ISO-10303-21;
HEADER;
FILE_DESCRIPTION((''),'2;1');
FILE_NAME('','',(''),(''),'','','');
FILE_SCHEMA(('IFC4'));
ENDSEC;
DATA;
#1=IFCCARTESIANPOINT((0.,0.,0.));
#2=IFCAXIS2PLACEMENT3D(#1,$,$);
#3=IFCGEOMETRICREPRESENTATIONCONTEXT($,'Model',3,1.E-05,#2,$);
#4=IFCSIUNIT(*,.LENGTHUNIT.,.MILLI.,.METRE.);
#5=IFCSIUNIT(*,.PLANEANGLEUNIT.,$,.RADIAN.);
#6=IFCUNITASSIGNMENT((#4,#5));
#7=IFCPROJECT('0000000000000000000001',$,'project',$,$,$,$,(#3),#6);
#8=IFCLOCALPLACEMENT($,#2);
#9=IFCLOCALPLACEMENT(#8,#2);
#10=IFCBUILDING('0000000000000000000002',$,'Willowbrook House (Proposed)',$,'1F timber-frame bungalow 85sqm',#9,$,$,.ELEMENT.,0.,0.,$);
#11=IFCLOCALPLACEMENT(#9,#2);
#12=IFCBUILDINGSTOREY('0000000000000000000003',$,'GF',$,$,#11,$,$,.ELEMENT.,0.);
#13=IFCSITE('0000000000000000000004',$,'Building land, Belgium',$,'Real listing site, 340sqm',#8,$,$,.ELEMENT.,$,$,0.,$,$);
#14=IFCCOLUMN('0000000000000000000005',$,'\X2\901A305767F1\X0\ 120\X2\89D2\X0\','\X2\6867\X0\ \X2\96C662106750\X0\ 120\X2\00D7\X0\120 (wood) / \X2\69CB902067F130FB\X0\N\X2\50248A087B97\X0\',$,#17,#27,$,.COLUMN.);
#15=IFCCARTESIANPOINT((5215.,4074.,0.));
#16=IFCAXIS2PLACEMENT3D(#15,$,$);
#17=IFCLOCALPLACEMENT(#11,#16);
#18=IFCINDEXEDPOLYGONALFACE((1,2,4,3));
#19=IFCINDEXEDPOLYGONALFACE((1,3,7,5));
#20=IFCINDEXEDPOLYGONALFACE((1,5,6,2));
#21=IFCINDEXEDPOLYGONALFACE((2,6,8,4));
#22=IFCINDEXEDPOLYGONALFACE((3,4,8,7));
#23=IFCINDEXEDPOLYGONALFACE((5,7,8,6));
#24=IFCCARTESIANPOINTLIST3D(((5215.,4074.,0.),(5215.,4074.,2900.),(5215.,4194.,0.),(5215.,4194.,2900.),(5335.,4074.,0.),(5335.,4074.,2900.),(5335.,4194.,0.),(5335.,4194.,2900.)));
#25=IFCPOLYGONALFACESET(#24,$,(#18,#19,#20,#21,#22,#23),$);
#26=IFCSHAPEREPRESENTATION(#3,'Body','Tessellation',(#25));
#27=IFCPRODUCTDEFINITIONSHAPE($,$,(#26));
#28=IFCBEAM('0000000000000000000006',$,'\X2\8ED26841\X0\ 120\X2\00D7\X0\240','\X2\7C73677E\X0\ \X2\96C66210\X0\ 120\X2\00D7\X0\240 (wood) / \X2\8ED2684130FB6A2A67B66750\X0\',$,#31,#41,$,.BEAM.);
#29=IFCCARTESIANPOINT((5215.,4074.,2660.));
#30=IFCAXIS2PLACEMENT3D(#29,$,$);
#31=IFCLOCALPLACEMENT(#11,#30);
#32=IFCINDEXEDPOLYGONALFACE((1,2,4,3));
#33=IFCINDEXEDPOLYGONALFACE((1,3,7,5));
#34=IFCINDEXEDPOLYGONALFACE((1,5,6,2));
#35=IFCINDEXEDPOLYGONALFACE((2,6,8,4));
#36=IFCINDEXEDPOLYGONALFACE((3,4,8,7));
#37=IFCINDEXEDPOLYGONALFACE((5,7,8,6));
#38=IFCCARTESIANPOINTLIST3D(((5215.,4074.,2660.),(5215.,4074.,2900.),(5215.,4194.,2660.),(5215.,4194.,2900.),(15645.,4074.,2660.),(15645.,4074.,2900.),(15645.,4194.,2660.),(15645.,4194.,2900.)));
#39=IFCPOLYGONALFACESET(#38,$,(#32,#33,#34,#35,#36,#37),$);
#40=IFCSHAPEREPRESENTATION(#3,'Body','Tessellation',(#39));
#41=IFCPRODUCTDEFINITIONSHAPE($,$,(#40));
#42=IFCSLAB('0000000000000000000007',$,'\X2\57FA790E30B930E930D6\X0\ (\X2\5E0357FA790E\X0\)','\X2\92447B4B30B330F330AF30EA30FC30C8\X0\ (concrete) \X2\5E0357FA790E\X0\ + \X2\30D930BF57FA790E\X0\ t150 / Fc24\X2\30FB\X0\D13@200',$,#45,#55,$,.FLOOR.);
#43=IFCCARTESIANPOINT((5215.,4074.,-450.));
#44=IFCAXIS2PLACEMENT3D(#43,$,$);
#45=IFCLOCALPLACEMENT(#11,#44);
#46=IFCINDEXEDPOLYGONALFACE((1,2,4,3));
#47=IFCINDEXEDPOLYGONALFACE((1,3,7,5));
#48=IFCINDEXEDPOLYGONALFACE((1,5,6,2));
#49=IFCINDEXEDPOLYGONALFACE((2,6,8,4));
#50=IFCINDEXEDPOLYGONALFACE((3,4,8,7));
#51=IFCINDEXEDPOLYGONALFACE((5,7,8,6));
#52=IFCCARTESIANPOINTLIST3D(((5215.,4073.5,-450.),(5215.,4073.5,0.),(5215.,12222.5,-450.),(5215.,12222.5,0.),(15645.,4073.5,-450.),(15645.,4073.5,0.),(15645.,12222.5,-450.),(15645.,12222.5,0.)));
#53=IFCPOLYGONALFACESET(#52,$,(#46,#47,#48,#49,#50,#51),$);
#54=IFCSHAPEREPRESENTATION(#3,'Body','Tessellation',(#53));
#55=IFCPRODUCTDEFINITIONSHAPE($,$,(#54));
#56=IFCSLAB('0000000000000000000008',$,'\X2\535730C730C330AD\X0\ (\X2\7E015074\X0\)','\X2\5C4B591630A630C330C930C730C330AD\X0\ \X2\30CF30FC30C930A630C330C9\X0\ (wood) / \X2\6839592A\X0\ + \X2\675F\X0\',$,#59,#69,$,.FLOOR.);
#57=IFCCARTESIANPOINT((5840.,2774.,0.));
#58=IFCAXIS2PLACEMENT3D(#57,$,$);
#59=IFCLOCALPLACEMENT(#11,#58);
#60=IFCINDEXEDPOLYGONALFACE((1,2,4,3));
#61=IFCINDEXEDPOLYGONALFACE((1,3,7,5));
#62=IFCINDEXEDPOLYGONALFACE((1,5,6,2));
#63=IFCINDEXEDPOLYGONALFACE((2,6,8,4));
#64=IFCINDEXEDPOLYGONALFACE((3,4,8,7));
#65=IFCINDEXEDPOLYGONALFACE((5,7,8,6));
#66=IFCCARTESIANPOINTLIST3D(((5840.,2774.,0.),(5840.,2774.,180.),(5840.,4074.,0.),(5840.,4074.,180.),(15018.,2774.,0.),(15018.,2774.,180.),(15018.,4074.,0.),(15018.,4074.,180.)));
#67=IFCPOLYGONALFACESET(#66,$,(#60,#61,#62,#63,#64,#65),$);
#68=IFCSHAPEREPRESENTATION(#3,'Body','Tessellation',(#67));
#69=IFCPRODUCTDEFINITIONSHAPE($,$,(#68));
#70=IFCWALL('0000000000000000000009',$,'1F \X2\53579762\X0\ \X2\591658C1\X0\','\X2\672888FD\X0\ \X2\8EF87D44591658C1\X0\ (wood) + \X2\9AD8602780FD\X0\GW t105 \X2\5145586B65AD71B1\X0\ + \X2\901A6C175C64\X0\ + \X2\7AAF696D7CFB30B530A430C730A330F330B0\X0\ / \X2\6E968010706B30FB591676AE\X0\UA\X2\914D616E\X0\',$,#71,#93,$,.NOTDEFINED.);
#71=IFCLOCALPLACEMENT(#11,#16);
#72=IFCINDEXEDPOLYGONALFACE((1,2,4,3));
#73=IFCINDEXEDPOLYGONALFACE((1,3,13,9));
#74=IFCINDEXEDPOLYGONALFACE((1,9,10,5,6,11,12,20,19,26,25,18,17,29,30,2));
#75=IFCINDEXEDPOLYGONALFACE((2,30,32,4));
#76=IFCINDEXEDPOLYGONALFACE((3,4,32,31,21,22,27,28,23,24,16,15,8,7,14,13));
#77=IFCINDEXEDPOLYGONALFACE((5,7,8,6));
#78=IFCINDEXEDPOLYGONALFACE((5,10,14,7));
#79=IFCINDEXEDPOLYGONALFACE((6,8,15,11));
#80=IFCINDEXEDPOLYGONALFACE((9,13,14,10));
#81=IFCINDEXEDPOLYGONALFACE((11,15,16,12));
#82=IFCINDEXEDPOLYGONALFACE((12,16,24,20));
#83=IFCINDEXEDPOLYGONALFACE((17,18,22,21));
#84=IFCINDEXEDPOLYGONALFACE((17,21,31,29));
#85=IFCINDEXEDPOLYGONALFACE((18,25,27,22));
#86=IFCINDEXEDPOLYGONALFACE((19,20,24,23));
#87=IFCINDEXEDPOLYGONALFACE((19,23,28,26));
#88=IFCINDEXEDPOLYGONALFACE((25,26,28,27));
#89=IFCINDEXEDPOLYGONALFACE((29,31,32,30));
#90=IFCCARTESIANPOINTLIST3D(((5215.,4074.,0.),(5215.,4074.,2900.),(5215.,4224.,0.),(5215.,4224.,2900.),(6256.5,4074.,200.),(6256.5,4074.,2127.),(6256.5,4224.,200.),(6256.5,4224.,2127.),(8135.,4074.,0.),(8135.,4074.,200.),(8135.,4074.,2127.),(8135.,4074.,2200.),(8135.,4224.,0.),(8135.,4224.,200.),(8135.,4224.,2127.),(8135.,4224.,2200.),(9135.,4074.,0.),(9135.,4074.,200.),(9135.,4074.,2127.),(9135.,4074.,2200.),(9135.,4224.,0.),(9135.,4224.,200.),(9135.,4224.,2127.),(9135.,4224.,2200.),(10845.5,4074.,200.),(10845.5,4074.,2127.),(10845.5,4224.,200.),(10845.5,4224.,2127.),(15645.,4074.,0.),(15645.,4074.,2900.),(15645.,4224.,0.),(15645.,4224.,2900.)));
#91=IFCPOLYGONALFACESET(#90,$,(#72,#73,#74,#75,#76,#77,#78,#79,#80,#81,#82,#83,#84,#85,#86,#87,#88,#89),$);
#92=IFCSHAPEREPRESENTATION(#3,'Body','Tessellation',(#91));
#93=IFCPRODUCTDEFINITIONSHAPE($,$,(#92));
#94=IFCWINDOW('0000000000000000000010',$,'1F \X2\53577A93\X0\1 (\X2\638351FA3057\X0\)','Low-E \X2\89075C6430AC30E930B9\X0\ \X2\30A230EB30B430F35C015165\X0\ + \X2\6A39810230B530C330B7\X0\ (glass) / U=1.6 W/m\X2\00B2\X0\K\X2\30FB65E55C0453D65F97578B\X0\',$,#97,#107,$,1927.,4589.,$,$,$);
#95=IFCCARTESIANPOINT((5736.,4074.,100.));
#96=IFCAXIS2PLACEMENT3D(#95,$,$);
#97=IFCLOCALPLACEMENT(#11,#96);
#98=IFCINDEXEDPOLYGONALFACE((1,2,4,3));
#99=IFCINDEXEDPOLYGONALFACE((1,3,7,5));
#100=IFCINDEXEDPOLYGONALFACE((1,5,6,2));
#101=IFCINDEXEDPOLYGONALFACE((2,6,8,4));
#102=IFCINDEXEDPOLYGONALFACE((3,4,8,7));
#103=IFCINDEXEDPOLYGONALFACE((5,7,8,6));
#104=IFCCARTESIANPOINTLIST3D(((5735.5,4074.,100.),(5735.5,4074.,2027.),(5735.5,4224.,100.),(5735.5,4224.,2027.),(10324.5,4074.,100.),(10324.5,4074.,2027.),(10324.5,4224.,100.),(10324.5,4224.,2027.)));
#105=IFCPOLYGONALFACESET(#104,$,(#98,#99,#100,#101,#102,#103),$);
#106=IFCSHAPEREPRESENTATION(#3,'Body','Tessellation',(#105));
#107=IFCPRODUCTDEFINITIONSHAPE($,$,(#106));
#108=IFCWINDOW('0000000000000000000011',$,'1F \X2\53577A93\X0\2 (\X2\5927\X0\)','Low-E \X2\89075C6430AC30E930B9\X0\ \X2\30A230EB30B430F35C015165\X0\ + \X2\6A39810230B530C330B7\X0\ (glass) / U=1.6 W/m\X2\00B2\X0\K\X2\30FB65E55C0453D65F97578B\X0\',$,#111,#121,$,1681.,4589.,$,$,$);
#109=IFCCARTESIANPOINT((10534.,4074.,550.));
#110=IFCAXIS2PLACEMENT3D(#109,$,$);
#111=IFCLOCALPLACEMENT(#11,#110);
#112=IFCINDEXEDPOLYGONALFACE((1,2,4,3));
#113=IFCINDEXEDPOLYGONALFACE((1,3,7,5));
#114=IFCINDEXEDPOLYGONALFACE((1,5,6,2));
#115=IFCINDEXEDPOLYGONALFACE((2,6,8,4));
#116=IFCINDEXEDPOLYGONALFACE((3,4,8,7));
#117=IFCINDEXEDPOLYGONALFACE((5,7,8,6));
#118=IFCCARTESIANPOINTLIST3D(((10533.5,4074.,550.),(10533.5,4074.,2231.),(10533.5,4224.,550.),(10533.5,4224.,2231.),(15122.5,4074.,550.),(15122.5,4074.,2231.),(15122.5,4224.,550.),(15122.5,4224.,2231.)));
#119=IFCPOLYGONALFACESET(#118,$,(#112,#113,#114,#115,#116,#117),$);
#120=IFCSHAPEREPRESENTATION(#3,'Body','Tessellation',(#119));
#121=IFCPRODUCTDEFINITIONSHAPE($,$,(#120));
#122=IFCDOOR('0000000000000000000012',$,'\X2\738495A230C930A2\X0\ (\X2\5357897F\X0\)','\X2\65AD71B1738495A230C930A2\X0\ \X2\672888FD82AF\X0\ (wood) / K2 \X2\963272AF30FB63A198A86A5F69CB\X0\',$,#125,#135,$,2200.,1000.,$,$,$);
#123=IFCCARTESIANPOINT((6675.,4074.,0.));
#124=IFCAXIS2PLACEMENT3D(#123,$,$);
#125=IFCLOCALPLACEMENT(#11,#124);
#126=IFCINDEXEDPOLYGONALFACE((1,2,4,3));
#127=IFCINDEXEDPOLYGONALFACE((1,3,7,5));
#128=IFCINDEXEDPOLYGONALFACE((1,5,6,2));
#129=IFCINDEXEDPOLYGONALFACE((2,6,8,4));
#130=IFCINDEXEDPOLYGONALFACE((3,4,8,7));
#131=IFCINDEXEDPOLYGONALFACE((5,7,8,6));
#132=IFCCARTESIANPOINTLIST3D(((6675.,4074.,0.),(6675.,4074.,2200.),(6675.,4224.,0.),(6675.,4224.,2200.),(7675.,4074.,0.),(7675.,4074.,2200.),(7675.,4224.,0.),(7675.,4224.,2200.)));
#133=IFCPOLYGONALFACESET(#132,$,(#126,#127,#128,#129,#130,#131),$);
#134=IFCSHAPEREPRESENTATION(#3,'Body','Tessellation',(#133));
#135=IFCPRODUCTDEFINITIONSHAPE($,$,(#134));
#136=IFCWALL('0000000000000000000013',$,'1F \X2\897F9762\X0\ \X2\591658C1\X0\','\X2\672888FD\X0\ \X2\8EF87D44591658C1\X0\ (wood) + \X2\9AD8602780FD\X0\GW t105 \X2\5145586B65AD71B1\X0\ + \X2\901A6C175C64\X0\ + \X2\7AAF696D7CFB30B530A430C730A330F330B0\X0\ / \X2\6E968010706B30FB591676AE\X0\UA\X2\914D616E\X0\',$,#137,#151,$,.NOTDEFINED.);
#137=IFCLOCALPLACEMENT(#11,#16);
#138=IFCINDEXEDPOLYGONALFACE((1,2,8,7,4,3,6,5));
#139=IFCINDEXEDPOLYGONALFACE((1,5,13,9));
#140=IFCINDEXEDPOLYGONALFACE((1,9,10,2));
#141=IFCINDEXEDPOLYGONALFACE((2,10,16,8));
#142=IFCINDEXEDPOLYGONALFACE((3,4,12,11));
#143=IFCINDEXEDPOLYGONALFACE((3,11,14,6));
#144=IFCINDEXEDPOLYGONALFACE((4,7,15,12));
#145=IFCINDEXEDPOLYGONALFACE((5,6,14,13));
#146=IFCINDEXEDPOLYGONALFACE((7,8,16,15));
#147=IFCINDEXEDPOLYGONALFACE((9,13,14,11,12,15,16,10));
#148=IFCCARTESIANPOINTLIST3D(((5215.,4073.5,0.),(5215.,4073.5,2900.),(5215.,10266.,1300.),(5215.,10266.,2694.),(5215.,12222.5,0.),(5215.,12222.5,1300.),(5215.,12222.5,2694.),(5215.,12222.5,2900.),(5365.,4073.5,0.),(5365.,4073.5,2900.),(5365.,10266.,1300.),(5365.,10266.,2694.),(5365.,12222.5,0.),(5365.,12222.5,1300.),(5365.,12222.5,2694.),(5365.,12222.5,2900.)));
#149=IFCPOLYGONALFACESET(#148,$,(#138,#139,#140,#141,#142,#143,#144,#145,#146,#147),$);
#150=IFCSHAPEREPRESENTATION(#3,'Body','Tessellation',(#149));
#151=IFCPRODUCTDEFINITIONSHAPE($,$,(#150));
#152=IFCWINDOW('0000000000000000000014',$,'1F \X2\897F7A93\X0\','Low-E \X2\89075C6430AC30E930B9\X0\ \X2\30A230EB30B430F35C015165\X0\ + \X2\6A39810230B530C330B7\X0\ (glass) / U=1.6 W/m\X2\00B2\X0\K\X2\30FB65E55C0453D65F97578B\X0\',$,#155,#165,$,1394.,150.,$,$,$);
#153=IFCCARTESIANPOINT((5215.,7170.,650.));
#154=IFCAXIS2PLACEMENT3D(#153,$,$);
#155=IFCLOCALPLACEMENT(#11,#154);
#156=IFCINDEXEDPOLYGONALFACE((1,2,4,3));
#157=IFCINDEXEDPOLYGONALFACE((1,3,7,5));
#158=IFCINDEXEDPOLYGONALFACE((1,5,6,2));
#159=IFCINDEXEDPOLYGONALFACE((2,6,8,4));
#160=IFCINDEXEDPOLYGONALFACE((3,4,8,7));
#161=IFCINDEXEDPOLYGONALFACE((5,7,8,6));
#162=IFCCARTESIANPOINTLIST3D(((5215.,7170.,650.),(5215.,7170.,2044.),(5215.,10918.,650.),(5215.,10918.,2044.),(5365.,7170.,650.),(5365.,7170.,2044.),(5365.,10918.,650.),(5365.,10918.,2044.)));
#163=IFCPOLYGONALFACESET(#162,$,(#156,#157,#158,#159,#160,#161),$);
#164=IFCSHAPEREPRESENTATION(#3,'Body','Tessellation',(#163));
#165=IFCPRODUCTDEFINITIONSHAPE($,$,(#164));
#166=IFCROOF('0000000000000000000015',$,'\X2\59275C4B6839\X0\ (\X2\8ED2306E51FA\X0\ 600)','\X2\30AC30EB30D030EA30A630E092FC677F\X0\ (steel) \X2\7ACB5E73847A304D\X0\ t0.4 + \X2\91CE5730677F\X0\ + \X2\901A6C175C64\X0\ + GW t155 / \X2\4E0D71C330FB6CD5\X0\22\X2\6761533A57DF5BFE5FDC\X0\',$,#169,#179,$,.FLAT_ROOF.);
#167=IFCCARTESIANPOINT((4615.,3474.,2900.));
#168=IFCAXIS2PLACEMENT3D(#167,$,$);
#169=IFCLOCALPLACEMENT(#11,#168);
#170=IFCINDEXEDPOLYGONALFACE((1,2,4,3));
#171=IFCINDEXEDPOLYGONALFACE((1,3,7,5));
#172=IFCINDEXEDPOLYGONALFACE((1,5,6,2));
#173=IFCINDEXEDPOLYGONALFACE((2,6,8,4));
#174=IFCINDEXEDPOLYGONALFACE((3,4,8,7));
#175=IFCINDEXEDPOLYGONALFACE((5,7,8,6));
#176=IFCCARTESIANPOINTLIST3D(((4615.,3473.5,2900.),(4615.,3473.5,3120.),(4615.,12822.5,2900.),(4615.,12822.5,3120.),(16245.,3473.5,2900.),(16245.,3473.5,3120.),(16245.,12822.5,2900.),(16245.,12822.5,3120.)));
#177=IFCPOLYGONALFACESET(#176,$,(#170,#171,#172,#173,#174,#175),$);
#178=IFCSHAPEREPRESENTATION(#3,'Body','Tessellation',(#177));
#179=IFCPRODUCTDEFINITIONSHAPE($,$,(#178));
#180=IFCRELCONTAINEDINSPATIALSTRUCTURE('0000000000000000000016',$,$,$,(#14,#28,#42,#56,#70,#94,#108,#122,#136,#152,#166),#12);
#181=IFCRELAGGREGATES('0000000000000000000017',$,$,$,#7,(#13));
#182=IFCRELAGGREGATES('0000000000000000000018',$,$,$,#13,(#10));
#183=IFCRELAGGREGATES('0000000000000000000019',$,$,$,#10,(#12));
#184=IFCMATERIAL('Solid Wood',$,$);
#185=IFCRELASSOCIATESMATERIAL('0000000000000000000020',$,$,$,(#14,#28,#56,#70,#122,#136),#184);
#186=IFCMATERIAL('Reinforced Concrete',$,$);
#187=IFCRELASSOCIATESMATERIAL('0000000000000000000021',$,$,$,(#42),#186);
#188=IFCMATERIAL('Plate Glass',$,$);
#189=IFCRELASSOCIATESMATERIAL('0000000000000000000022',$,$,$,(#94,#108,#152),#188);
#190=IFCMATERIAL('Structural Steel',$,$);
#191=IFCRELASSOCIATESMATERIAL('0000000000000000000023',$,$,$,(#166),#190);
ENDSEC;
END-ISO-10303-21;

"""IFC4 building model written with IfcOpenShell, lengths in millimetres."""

from ifc_helpers import new_model, si_unit, frame, frame_2d, origin, place, context, project, spatial, rectangle, extrude, material, element, fill, save


model = new_model("IFC4")

# Units and contexts
model_context = context("Model", 3, precision=1e-05, world=origin())
ifc_project = project(units=[si_unit("LENGTHUNIT", "METRE", prefix="MILLI"), si_unit("PLANEANGLEUNIT", "RADIAN")], contexts=[model_context])

# Site, building, storey
site_placement = place(None, origin())
site = spatial("IfcSite", under=ifc_project, at=site_placement, Name="Building land, Belgium", ObjectType="Real listing site, 340sqm", CompositionType="ELEMENT", RefElevation=0.0)
building_placement = place(site_placement, origin())
building = spatial("IfcBuilding", under=site, at=building_placement, Name="Willowbrook House (Proposed)", ObjectType="1F timber-frame bungalow 85sqm", CompositionType="ELEMENT", ElevationOfRefHeight=0.0, ElevationOfTerrain=0.0)
storey_placement = place(building_placement, origin())
storey = spatial("IfcBuildingStorey", under=building, at=storey_placement, Name="GF", CompositionType="ELEMENT", Elevation=0.0)

# Column
ifc_material_1 = material(Name="Solid Wood")
column_1_placement = place(storey_placement, frame((5215.0, 4074.0, 0.0)))
element("IfcColumn", 1, at=column_1_placement, inside=storey, material=ifc_material_1, Name="通し柱 120角", Description="桧 集成材 120×120 (wood) / 構造柱・N値計算", PredefinedType="COLUMN", context=model_context, shape_type="SweptSolid", body=[
    extrude(rectangle(XDim=120.0, YDim=120.0, at=frame_2d((60.0, 60.0))), frame((5215.0, 4074.0, 0.0)), (0.0, 0.0, 1.0), 2900.0),
])

# Beam
beam_1_placement = place(storey_placement, frame((5215.0, 4074.0, 2660.0)))
element("IfcBeam", 2, at=beam_1_placement, inside=storey, material=ifc_material_1, Name="軒桁 120×240", Description="米松 集成 120×240 (wood) / 軒桁・横架材", PredefinedType="BEAM", context=model_context, shape_type="SweptSolid", body=[
    extrude(rectangle(XDim=10430.0, YDim=120.0, at=frame_2d((5215.0, 60.0))), frame((5215.0, 4074.0, 2660.0)), (0.0, 0.0, 1.0), 240.0),
])

# Slabs
ifc_material_2 = material(Name="Reinforced Concrete")
slab_1_placement = place(storey_placement, frame((5215.0, 4074.0, -450.0)))
element("IfcSlab", 3, at=slab_1_placement, inside=storey, material=ifc_material_2, Name="基礎スラブ (布基礎)", Description="鉄筋コンクリート (concrete) 布基礎 + ベタ基礎 t150 / Fc24・D13@200", PredefinedType="FLOOR", context=model_context, shape_type="SweptSolid", body=[
    extrude(rectangle(XDim=10430.0, YDim=8149.0, at=frame_2d((5215.0, 4074.0))), frame((5215.0, 4074.0, -450.0)), (0.0, 0.0, 1.0), 450.0),
])
slab_2_placement = place(storey_placement, frame((5840.0, 2774.0, 0.0)))
element("IfcSlab", 4, at=slab_2_placement, inside=storey, material=ifc_material_1, Name="南デッキ (縁側)", Description="屋外ウッドデッキ ハードウッド (wood) / 根太 + 束", PredefinedType="FLOOR", context=model_context, shape_type="SweptSolid", body=[
    extrude(rectangle(XDim=9178.0, YDim=1300.0, at=frame_2d((4589.0, 650.0))), frame((5840.0, 2774.0, 0.0)), (0.0, 0.0, 1.0), 180.0),
])

# Wall, openings, windows, door
wall_1_placement = place(storey_placement, frame((5215.0, 4074.0, 0.0)))
wall_1 = element("IfcWall", 5, at=wall_1_placement, inside=storey, material=ifc_material_1, Name="1F 南面 外壁", Description="木製 軸組外壁 (wood) + 高性能GW t105 充填断熱 + 通気層 + 窯業系サイディング / 準耐火・外皮UA配慮", PredefinedType="NOTDEFINED", context=model_context, shape_type="SweptSolid", body=[
    extrude(rectangle(XDim=10430.0, YDim=150.0, at=frame_2d((5215.0, 75.0))), frame((5215.0, 4074.0, 0.0)), (0.0, 0.0, 1.0), 2900.0),
])
opening_1_placement = place(storey_placement, frame((5736.0, 4074.0, 100.0)))
opening_1 = element("IfcOpeningElement", 6, at=opening_1_placement, cuts=wall_1, PredefinedType="NOTDEFINED", context=model_context, shape_type="SweptSolid", body=[
    extrude(rectangle(XDim=4589.0, YDim=150.0, at=frame_2d((2294.0, 75.0))), frame((5736.0, 4074.0, 100.0)), (0.0, 0.0, 1.0), 1927.0),
])
opening_2_placement = place(storey_placement, frame((10534.0, 4074.0, 550.0)))
opening_2 = element("IfcOpeningElement", 7, at=opening_2_placement, cuts=wall_1, PredefinedType="NOTDEFINED", context=model_context, shape_type="SweptSolid", body=[
    extrude(rectangle(XDim=4589.0, YDim=150.0, at=frame_2d((2294.0, 75.0))), frame((10534.0, 4074.0, 550.0)), (0.0, 0.0, 1.0), 1681.0),
])
opening_3_placement = place(storey_placement, frame((6675.0, 4074.0, 0.0)))
opening_3 = element("IfcOpeningElement", 8, at=opening_3_placement, cuts=wall_1, PredefinedType="NOTDEFINED", context=model_context, shape_type="SweptSolid", body=[
    extrude(rectangle(XDim=1000.0, YDim=150.0, at=frame_2d((500.0, 75.0))), frame((6675.0, 4074.0, 0.0)), (0.0, 0.0, 1.0), 2200.0),
])
ifc_material_3 = material(Name="Plate Glass")
window_1_placement = place(storey_placement, frame((5736.0, 4074.0, 100.0)))
window_1 = element("IfcWindow", 9, at=window_1_placement, inside=storey, material=ifc_material_3, Name="1F 南窓1 (掃出し)", Description="Low-E 複層ガラス アルゴン封入 + 樹脂サッシ (glass) / U=1.6 W/m²K・日射取得型", OverallHeight=1927.0, OverallWidth=4589.0, context=model_context, shape_type="SweptSolid", body=[
    extrude(rectangle(XDim=4589.0, YDim=150.0, at=frame_2d((2294.0, 75.0))), frame((5736.0, 4074.0, 100.0)), (0.0, 0.0, 1.0), 1927.0),
])
fill(opening_1, window_1)
window_2_placement = place(storey_placement, frame((10534.0, 4074.0, 550.0)))
window_2 = element("IfcWindow", 10, at=window_2_placement, inside=storey, material=ifc_material_3, Name="1F 南窓2 (大)", Description="Low-E 複層ガラス アルゴン封入 + 樹脂サッシ (glass) / U=1.6 W/m²K・日射取得型", OverallHeight=1681.0, OverallWidth=4589.0, context=model_context, shape_type="SweptSolid", body=[
    extrude(rectangle(XDim=4589.0, YDim=150.0, at=frame_2d((2294.0, 75.0))), frame((10534.0, 4074.0, 550.0)), (0.0, 0.0, 1.0), 1681.0),
])
fill(opening_2, window_2)
door_placement = place(storey_placement, frame((6675.0, 4074.0, 0.0)))
door = element("IfcDoor", 11, at=door_placement, inside=storey, material=ifc_material_1, Name="玄関ドア (南西)", Description="断熱玄関ドア 木製芯 (wood) / K2 防犯・採風機構", OverallHeight=2200.0, OverallWidth=1000.0, context=model_context, shape_type="SweptSolid", body=[
    extrude(rectangle(XDim=1000.0, YDim=150.0, at=frame_2d((500.0, 75.0))), frame((6675.0, 4074.0, 0.0)), (0.0, 0.0, 1.0), 2200.0),
])
fill(opening_3, door)

# Wall, opening, window
wall_2_placement = place(storey_placement, frame((5215.0, 4074.0, 0.0)))
wall_2 = element("IfcWall", 12, at=wall_2_placement, inside=storey, material=ifc_material_1, Name="1F 西面 外壁", Description="木製 軸組外壁 (wood) + 高性能GW t105 充填断熱 + 通気層 + 窯業系サイディング / 準耐火・外皮UA配慮", PredefinedType="NOTDEFINED", context=model_context, shape_type="SweptSolid", body=[
    extrude(rectangle(XDim=150.0, YDim=8149.0, at=frame_2d((75.0, 4074.0))), frame((5215.0, 4074.0, 0.0)), (0.0, 0.0, 1.0), 2900.0),
])
opening_4_placement = place(storey_placement, frame((5215.0, 7170.0, 650.0)))
opening_4 = element("IfcOpeningElement", 13, at=opening_4_placement, cuts=wall_2, PredefinedType="NOTDEFINED", context=model_context, shape_type="SweptSolid", body=[
    extrude(rectangle(XDim=150.0, YDim=3748.0, at=frame_2d((75.0, 1874.0))), frame((5215.0, 7170.0, 650.0)), (0.0, 0.0, 1.0), 1394.0),
])
window_3_placement = place(storey_placement, frame((5215.0, 7170.0, 650.0)))
window_3 = element("IfcWindow", 14, at=window_3_placement, inside=storey, material=ifc_material_3, Name="1F 西窓", Description="Low-E 複層ガラス アルゴン封入 + 樹脂サッシ (glass) / U=1.6 W/m²K・日射取得型", OverallHeight=1394.0, OverallWidth=150.0, context=model_context, shape_type="SweptSolid", body=[
    extrude(rectangle(XDim=150.0, YDim=3748.0, at=frame_2d((75.0, 1874.0))), frame((5215.0, 7170.0, 650.0)), (0.0, 0.0, 1.0), 1394.0),
])
fill(opening_4, window_3)

# Roof
ifc_material_4 = material(Name="Structural Steel")
roof_placement = place(storey_placement, frame((4615.0, 3474.0, 2900.0)))
element("IfcRoof", 15, at=roof_placement, inside=storey, material=ifc_material_4, Name="大屋根 (軒の出 600)", Description="ガルバリウム鋼板 (steel) 立平葺き t0.4 + 野地板 + 通気層 + GW t155 / 不燃・法22条区域対応", PredefinedType="FLAT_ROOF", context=model_context, shape_type="SweptSolid", body=[
    extrude(rectangle(XDim=11630.0, YDim=9349.0, at=frame_2d((5815.0, 4674.0))), frame((4615.0, 3474.0, 2900.0)), (0.0, 0.0, 1.0), 220.0),
])

save(model, "model.ifc")
